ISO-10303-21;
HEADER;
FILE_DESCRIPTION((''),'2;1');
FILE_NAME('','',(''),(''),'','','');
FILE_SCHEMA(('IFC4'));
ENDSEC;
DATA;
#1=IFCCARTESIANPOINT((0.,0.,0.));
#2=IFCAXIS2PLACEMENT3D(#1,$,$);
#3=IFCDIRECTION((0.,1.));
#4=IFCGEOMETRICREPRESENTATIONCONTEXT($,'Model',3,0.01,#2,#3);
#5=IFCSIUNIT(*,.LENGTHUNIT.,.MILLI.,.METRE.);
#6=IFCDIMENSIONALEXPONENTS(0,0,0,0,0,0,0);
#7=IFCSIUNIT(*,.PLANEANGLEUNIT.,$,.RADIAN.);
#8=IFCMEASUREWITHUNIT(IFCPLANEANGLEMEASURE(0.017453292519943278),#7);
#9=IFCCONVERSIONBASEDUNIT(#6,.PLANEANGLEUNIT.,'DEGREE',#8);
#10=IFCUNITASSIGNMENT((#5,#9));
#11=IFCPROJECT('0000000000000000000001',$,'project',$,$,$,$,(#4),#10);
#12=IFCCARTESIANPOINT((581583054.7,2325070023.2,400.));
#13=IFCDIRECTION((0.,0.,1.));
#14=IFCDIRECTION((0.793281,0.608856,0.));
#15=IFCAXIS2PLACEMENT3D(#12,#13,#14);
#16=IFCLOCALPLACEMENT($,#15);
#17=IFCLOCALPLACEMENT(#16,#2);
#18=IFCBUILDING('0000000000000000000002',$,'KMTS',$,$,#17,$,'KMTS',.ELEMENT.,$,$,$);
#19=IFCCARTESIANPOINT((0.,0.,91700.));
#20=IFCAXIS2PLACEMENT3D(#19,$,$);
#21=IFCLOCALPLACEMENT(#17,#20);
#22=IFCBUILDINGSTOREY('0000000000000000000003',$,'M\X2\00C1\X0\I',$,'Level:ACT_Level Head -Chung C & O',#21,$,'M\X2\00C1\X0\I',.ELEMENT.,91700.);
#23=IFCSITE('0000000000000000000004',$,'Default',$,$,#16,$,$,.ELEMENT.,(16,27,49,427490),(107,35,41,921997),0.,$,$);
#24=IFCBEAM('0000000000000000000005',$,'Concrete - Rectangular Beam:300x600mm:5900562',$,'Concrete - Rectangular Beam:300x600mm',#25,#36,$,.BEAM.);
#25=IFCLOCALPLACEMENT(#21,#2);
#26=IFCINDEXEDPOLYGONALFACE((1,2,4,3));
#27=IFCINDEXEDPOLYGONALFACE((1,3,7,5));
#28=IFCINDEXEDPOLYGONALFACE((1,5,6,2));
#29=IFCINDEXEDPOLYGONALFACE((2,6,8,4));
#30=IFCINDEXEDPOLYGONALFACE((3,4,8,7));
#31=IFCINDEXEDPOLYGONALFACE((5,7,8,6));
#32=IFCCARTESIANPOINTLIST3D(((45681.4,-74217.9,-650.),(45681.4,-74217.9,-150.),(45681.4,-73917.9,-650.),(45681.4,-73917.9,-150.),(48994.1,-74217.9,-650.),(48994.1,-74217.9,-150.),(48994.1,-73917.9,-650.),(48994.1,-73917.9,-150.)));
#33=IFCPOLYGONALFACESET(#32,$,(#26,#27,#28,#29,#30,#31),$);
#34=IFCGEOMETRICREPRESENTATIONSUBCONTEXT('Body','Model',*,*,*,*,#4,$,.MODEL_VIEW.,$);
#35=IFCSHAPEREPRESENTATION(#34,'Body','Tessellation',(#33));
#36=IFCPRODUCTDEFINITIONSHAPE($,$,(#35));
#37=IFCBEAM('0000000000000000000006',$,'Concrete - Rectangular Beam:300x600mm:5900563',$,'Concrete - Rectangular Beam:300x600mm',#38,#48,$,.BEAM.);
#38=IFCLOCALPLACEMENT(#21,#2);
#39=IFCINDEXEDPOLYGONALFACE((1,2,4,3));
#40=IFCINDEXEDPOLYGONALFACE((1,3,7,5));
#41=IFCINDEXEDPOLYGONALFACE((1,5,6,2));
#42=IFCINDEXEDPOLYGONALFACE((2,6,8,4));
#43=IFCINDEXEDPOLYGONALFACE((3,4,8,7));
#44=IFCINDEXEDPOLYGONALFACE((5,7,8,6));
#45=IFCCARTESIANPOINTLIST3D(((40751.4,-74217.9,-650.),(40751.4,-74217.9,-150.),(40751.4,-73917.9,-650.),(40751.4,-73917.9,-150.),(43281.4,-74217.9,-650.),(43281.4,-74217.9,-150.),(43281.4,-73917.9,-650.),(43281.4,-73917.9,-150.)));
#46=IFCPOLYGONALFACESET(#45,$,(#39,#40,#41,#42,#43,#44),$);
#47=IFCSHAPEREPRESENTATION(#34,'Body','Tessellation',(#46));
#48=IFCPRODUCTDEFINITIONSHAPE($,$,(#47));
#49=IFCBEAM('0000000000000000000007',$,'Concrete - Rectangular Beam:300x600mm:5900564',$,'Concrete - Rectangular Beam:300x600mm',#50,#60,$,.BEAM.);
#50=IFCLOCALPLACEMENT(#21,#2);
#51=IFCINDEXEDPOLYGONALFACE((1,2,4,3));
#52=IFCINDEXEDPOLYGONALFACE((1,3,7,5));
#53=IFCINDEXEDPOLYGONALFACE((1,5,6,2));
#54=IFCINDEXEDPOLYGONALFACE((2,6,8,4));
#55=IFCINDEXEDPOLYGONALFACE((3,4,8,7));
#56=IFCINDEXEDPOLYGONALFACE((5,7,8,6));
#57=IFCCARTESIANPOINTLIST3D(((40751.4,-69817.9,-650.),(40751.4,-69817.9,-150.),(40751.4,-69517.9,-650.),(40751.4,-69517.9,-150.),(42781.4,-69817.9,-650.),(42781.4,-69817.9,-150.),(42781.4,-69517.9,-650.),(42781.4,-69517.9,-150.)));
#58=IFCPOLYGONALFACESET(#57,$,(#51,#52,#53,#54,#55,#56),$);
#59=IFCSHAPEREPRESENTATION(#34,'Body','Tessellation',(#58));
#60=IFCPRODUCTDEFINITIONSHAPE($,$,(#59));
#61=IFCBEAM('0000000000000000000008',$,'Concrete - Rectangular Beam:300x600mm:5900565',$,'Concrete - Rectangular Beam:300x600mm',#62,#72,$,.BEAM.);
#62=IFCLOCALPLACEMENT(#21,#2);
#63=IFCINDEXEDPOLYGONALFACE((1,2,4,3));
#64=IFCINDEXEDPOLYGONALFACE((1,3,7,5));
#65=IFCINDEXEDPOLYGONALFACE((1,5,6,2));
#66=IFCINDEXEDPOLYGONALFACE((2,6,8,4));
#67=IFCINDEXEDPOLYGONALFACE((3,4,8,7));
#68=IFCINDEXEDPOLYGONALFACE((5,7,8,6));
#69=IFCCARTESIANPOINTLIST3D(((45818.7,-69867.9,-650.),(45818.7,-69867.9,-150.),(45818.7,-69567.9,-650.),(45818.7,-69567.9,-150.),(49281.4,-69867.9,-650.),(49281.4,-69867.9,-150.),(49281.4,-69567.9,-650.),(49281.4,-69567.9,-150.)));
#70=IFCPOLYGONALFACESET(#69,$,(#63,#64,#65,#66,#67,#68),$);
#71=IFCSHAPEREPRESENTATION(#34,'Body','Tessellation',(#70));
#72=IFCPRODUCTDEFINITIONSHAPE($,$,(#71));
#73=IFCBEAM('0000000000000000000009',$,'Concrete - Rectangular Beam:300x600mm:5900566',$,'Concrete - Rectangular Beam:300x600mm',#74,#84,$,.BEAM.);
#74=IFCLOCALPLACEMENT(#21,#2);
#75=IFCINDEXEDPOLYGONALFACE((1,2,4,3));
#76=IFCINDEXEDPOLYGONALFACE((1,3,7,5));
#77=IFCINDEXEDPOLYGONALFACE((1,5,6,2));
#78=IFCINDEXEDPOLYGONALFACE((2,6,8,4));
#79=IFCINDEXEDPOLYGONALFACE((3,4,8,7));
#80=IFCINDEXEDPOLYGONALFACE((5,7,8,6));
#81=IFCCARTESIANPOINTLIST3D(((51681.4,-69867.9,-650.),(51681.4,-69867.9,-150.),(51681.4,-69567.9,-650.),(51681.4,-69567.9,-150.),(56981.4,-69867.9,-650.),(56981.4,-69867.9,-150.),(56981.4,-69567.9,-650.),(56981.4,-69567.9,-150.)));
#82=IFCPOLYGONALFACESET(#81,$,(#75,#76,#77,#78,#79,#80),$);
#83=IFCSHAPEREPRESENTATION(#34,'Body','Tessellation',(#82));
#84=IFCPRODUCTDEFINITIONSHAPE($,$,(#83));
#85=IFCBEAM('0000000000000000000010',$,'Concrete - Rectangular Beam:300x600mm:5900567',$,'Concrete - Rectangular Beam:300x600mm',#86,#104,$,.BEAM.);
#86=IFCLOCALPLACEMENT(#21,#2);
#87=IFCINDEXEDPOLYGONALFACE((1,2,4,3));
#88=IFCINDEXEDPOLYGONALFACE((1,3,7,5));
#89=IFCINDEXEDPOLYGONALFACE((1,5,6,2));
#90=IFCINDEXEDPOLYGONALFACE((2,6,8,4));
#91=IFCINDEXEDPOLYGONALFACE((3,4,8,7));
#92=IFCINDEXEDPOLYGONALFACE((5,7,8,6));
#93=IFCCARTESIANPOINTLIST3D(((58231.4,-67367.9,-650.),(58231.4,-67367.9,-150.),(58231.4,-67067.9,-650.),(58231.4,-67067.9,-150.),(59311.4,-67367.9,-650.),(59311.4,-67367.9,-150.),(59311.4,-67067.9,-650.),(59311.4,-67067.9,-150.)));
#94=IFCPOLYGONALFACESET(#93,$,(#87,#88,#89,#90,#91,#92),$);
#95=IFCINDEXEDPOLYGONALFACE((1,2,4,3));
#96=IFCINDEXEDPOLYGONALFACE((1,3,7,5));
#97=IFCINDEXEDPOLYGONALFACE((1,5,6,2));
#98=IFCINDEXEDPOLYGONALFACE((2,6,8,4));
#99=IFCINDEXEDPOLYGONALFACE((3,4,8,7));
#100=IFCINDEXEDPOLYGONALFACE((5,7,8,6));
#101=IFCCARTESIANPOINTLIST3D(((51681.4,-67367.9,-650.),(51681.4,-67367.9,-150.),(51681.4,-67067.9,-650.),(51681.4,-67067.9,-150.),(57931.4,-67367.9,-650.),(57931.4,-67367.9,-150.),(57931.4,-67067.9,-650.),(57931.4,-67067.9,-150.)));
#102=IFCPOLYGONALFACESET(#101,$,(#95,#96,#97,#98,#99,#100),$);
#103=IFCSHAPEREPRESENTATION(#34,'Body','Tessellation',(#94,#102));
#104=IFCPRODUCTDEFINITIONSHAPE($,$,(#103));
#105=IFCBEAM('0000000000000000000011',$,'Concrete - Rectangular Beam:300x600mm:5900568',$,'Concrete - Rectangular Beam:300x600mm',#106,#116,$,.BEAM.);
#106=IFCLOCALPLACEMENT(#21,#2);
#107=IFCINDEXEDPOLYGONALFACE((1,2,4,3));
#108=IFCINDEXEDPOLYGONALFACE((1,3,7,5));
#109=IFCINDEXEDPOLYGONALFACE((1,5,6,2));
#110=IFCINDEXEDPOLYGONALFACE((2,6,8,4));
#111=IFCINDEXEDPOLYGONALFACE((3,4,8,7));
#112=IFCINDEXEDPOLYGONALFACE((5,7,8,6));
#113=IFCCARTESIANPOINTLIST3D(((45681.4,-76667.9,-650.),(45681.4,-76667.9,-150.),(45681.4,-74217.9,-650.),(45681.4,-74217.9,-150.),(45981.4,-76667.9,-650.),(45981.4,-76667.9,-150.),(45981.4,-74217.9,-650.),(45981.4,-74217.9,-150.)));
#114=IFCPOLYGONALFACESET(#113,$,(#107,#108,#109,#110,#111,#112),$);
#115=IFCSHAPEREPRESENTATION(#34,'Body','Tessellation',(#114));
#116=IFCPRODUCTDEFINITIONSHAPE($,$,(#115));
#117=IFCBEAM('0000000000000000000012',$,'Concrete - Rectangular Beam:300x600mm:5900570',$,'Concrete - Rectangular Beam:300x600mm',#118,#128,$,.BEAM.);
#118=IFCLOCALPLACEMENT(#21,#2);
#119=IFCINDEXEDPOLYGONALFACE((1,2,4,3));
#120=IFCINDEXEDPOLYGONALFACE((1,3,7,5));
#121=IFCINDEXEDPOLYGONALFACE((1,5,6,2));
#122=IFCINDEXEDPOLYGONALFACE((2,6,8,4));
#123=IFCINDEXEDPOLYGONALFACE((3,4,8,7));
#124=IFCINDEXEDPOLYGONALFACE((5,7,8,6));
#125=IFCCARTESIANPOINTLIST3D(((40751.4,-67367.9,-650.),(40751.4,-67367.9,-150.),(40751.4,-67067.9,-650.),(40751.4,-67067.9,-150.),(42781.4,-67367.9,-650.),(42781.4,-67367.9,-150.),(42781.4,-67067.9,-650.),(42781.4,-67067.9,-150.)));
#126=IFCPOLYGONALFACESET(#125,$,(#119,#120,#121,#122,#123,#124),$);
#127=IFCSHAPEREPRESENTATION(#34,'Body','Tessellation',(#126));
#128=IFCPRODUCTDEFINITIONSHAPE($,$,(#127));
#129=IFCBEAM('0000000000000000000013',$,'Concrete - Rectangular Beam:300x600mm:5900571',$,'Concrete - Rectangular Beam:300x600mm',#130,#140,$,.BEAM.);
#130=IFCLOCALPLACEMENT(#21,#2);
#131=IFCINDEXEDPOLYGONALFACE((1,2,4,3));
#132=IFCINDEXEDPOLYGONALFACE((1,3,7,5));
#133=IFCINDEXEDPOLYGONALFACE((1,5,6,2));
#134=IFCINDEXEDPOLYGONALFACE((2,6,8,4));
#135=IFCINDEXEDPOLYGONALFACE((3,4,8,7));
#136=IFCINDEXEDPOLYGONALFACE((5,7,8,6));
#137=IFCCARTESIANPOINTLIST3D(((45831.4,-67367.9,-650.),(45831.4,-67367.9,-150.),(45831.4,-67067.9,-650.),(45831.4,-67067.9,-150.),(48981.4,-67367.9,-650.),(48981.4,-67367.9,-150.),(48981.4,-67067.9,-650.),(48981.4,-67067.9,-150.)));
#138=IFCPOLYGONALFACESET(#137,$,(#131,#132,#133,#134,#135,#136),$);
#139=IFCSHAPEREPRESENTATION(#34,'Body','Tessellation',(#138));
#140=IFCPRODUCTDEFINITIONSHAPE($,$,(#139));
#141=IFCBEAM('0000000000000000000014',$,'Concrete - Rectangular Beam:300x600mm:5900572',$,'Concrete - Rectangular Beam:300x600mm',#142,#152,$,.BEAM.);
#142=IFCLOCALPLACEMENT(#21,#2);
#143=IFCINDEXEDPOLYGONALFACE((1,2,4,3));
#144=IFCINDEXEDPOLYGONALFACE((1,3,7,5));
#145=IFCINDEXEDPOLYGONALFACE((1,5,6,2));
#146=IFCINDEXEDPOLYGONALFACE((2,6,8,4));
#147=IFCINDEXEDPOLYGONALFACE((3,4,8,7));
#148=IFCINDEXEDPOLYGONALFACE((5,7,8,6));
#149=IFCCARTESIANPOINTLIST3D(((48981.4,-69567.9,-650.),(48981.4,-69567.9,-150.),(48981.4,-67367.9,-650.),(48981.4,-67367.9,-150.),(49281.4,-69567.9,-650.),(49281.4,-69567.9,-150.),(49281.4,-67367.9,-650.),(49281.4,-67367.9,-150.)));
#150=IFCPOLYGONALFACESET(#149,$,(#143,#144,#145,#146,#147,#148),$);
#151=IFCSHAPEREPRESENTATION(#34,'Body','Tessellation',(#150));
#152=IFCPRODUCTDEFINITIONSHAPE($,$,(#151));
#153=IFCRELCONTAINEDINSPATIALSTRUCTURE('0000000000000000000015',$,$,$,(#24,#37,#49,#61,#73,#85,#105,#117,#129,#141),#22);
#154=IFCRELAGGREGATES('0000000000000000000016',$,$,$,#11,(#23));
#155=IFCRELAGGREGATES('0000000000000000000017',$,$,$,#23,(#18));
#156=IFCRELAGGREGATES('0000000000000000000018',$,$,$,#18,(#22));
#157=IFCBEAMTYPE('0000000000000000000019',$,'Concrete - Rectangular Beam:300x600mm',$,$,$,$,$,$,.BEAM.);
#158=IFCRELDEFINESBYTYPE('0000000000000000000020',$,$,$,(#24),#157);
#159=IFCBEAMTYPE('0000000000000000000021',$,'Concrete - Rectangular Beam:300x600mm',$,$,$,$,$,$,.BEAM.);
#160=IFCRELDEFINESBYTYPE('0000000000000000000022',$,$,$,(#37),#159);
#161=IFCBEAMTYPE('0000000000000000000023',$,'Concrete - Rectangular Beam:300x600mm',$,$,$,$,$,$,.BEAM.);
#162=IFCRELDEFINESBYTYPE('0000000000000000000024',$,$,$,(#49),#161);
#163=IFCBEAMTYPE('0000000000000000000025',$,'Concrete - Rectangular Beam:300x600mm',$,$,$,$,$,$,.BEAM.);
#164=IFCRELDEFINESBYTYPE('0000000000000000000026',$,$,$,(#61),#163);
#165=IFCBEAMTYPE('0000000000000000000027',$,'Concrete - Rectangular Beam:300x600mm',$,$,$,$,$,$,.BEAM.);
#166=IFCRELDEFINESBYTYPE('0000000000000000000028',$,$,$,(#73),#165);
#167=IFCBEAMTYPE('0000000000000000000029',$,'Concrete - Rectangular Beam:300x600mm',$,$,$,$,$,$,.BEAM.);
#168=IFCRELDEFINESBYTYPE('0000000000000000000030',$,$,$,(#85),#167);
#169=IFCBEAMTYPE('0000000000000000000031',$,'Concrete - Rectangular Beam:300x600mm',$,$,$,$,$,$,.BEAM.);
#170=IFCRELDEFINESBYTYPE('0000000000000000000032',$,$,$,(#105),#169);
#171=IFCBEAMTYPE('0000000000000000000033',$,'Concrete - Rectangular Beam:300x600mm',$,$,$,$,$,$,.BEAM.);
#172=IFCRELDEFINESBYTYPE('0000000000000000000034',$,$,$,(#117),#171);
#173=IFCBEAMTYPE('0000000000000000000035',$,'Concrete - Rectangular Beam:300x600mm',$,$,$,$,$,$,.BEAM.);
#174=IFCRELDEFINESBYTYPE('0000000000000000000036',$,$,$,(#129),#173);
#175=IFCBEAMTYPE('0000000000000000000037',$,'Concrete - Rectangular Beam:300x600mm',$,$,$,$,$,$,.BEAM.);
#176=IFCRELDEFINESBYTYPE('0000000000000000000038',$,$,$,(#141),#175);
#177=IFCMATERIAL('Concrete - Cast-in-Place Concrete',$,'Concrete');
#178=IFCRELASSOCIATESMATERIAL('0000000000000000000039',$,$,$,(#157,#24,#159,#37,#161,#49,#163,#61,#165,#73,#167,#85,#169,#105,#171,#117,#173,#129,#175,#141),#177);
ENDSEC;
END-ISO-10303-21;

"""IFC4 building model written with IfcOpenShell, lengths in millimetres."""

from ifc_helpers import new_model, entity, si_unit, converted_unit, direction, frame, origin, place, context, subcontext, project, spatial, indexed_curve, outline, extrude, source, transform, mapped, material, type_object, type_shapes, element, save


model = new_model("IFC4")

# Units and contexts
model_context = context("Model", 3, precision=0.01, world=origin(), true_north=direction((0.0, 1.0)))
body_context = subcontext(model_context, "Body", "Model", "MODEL_VIEW")
ifc_project = project(units=[si_unit("LENGTHUNIT", "METRE", prefix="MILLI"), converted_unit("PLANEANGLEUNIT", "DEGREE", entity("IfcPlaneAngleMeasure", 0.017453292519943278), si_unit("PLANEANGLEUNIT", "RADIAN"), dimensions=[0, 0, 0, 0, 0, 0, 0])], contexts=[model_context])

# Site, building, storey
site_placement = place(None, frame((581583054.7, 2325070023.2, 400.0), z_axis=(0.0, 0.0, 1.0), x_axis=(0.793281, 0.608856, 0.0)))
site = spatial("IfcSite", under=ifc_project, at=site_placement, Name="Default", CompositionType="ELEMENT", RefLatitude=(16, 27, 49, 427490), RefLongitude=(107, 35, 41, 921997), RefElevation=0.0)
building_placement = place(site_placement, origin())
building = spatial("IfcBuilding", under=site, at=building_placement, Name="KMTS", LongName="KMTS", CompositionType="ELEMENT")
storey_placement = place(building_placement, frame((0.0, 0.0, 91700.0)))
storey = spatial("IfcBuildingStorey", under=building, at=storey_placement, Name="MÁI", ObjectType="Level:ACT_Level Head -Chung C & O", LongName="MÁI", CompositionType="ELEMENT", Elevation=91700.0)

# Beams
ifc_material_1 = material(Name="Concrete - Cast-in-Place Concrete", Category="Concrete")
beam_type_1 = type_object("IfcBeamType", Name="Concrete - Rectangular Beam:300x600mm", PredefinedType="BEAM", material=ifc_material_1)
shared_shape_1 = source(origin(), body_context, "Body", "SweptSolid", [
    extrude(outline(indexed_curve([(-250.0, -150.0), (250.0, -150.0), (250.0, 150.0), (-250.0, 150.0), (-250.0, -150.0)], self_intersect=False)), frame((48994.1, -74067.9, 91300.0), z_axis=(-1.0, 0.0, 0.0), x_axis=(0.0, 0.0, -1.0)), (0.0, 0.0, 1.0), 3312.7),
])
type_shapes(beam_type_1, [shared_shape_1])
beam_1_placement = place(storey_placement, frame((0.0, 0.0, -91700.0)))
element("IfcBeam", 1, at=beam_1_placement, inside=storey, type_object=beam_type_1, material=ifc_material_1, Name="Concrete - Rectangular Beam:300x600mm:5900562", ObjectType="Concrete - Rectangular Beam:300x600mm", PredefinedType="BEAM", context=body_context, shape_type="MappedRepresentation", body=[
    mapped(shared_shape_1, transform((0.0, 0.0, 0.0), scale=1.0)),
])
beam_type_2 = type_object("IfcBeamType", Name="Concrete - Rectangular Beam:300x600mm", PredefinedType="BEAM", material=ifc_material_1)
shared_shape_2 = source(origin(), body_context, "Body", "SweptSolid", [
    extrude(outline(indexed_curve([(-250.0, -150.0), (250.0, -150.0), (250.0, 150.0), (-250.0, 150.0), (-250.0, -150.0)], self_intersect=False)), frame((43281.4, -74067.9, 91300.0), z_axis=(-1.0, 0.0, 0.0), x_axis=(0.0, 0.0, -1.0)), (0.0, 0.0, 1.0), 2530.0),
])
type_shapes(beam_type_2, [shared_shape_2])
beam_2_placement = place(storey_placement, frame((0.0, 0.0, -91700.0)))
element("IfcBeam", 2, at=beam_2_placement, inside=storey, type_object=beam_type_2, material=ifc_material_1, Name="Concrete - Rectangular Beam:300x600mm:5900563", ObjectType="Concrete - Rectangular Beam:300x600mm", PredefinedType="BEAM", context=body_context, shape_type="MappedRepresentation", body=[
    mapped(shared_shape_2, transform((0.0, 0.0, 0.0), scale=1.0)),
])
beam_type_3 = type_object("IfcBeamType", Name="Concrete - Rectangular Beam:300x600mm", PredefinedType="BEAM", material=ifc_material_1)
shared_shape_3 = source(origin(), body_context, "Body", "SweptSolid", [
    extrude(outline(indexed_curve([(-250.0, -150.0), (250.0, -150.0), (250.0, 150.0), (-250.0, 150.0), (-250.0, -150.0)], self_intersect=False)), frame((42781.4, -69667.9, 91300.0), z_axis=(-1.0, 0.0, 0.0), x_axis=(0.0, 0.0, -1.0)), (0.0, 0.0, 1.0), 2030.0),
])
type_shapes(beam_type_3, [shared_shape_3])
beam_3_placement = place(storey_placement, frame((0.0, 0.0, -91700.0)))
element("IfcBeam", 3, at=beam_3_placement, inside=storey, type_object=beam_type_3, material=ifc_material_1, Name="Concrete - Rectangular Beam:300x600mm:5900564", ObjectType="Concrete - Rectangular Beam:300x600mm", PredefinedType="BEAM", context=body_context, shape_type="MappedRepresentation", body=[
    mapped(shared_shape_3, transform((0.0, 0.0, 0.0), scale=1.0)),
])
beam_type_4 = type_object("IfcBeamType", Name="Concrete - Rectangular Beam:300x600mm", PredefinedType="BEAM", material=ifc_material_1)
shared_shape_4 = source(origin(), body_context, "Body", "SweptSolid", [
    extrude(outline(indexed_curve([(-250.0, -150.0), (250.0, -150.0), (250.0, 150.0), (-250.0, 150.0), (-250.0, -150.0)], self_intersect=False)), frame((49281.4, -69717.9, 91300.0), z_axis=(-1.0, 0.0, 0.0), x_axis=(0.0, 0.0, -1.0)), (0.0, 0.0, 1.0), 3462.7),
])
type_shapes(beam_type_4, [shared_shape_4])
beam_4_placement = place(storey_placement, frame((0.0, 0.0, -91700.0)))
element("IfcBeam", 4, at=beam_4_placement, inside=storey, type_object=beam_type_4, material=ifc_material_1, Name="Concrete - Rectangular Beam:300x600mm:5900565", ObjectType="Concrete - Rectangular Beam:300x600mm", PredefinedType="BEAM", context=body_context, shape_type="MappedRepresentation", body=[
    mapped(shared_shape_4, transform((0.0, 0.0, 0.0), scale=1.0)),
])
beam_type_5 = type_object("IfcBeamType", Name="Concrete - Rectangular Beam:300x600mm", PredefinedType="BEAM", material=ifc_material_1)
shared_shape_5 = source(origin(), body_context, "Body", "SweptSolid", [
    extrude(outline(indexed_curve([(-250.0, -150.0), (250.0, -150.0), (250.0, 150.0), (-250.0, 150.0), (-250.0, -150.0)], self_intersect=False)), frame((56981.4, -69717.9, 91300.0), z_axis=(-1.0, 0.0, 0.0), x_axis=(0.0, 0.0, -1.0)), (0.0, 0.0, 1.0), 5300.0),
])
type_shapes(beam_type_5, [shared_shape_5])
beam_5_placement = place(storey_placement, frame((0.0, 0.0, -91700.0)))
element("IfcBeam", 5, at=beam_5_placement, inside=storey, type_object=beam_type_5, material=ifc_material_1, Name="Concrete - Rectangular Beam:300x600mm:5900566", ObjectType="Concrete - Rectangular Beam:300x600mm", PredefinedType="BEAM", context=body_context, shape_type="MappedRepresentation", body=[
    mapped(shared_shape_5, transform((0.0, 0.0, 0.0), scale=1.0)),
])
beam_type_6 = type_object("IfcBeamType", Name="Concrete - Rectangular Beam:300x600mm", PredefinedType="BEAM", material=ifc_material_1)
shared_shape_6 = source(origin(), body_context, "Body", "SweptSolid", [
    extrude(outline(indexed_curve([(-250.0, -150.0), (250.0, -150.0), (250.0, 150.0), (-250.0, 150.0), (-250.0, -150.0)], self_intersect=False)), frame((59311.4, -67217.9, 91300.0), z_axis=(-1.0, 0.0, 0.0), x_axis=(0.0, 0.0, -1.0)), (0.0, 0.0, 1.0), 1080.0),
    extrude(outline(indexed_curve([(-250.0, -150.0), (250.0, -150.0), (250.0, 150.0), (-250.0, 150.0), (-250.0, -150.0)], self_intersect=False)), frame((57931.4, -67217.9, 91300.0), z_axis=(-1.0, 0.0, 0.0), x_axis=(0.0, 0.0, -1.0)), (0.0, 0.0, 1.0), 6250.0),
])
type_shapes(beam_type_6, [shared_shape_6])
beam_6_placement = place(storey_placement, frame((0.0, 0.0, -91700.0)))
element("IfcBeam", 6, at=beam_6_placement, inside=storey, type_object=beam_type_6, material=ifc_material_1, Name="Concrete - Rectangular Beam:300x600mm:5900567", ObjectType="Concrete - Rectangular Beam:300x600mm", PredefinedType="BEAM", context=body_context, shape_type="MappedRepresentation", body=[
    mapped(shared_shape_6, transform((0.0, 0.0, 0.0), scale=1.0)),
])
beam_type_7 = type_object("IfcBeamType", Name="Concrete - Rectangular Beam:300x600mm", PredefinedType="BEAM", material=ifc_material_1)
shared_shape_7 = source(origin(), body_context, "Body", "SweptSolid", [
    extrude(outline(indexed_curve([(-150.0, -250.0), (150.0, -250.0), (150.0, 250.0), (-150.0, 250.0), (-150.0, -250.0)], self_intersect=False)), frame((45831.4, -76667.9, 91300.0), z_axis=(0.0, 1.0, 0.0), x_axis=(-1.0, 0.0, 0.0)), (0.0, 0.0, 1.0), 2450.0),
])
type_shapes(beam_type_7, [shared_shape_7])
beam_7_placement = place(storey_placement, frame((0.0, 0.0, -91700.0)))
element("IfcBeam", 7, at=beam_7_placement, inside=storey, type_object=beam_type_7, material=ifc_material_1, Name="Concrete - Rectangular Beam:300x600mm:5900568", ObjectType="Concrete - Rectangular Beam:300x600mm", PredefinedType="BEAM", context=body_context, shape_type="MappedRepresentation", body=[
    mapped(shared_shape_7, transform((0.0, 0.0, 0.0), scale=1.0)),
])
beam_type_8 = type_object("IfcBeamType", Name="Concrete - Rectangular Beam:300x600mm", PredefinedType="BEAM", material=ifc_material_1)
shared_shape_8 = source(origin(), body_context, "Body", "SweptSolid", [
    extrude(outline(indexed_curve([(-250.0, -150.0), (250.0, -150.0), (250.0, 150.0), (-250.0, 150.0), (-250.0, -150.0)], self_intersect=False)), frame((42781.4, -67217.9, 91300.0), z_axis=(-1.0, 0.0, 0.0), x_axis=(0.0, 0.0, -1.0)), (0.0, 0.0, 1.0), 2030.0),
])
type_shapes(beam_type_8, [shared_shape_8])
beam_8_placement = place(storey_placement, frame((0.0, 0.0, -91700.0)))
element("IfcBeam", 8, at=beam_8_placement, inside=storey, type_object=beam_type_8, material=ifc_material_1, Name="Concrete - Rectangular Beam:300x600mm:5900570", ObjectType="Concrete - Rectangular Beam:300x600mm", PredefinedType="BEAM", context=body_context, shape_type="MappedRepresentation", body=[
    mapped(shared_shape_8, transform((0.0, 0.0, 0.0), scale=1.0)),
])
beam_type_9 = type_object("IfcBeamType", Name="Concrete - Rectangular Beam:300x600mm", PredefinedType="BEAM", material=ifc_material_1)
shared_shape_9 = source(origin(), body_context, "Body", "SweptSolid", [
    extrude(outline(indexed_curve([(-250.0, -150.0), (250.0, -150.0), (250.0, 150.0), (-250.0, 150.0), (-250.0, -150.0)], self_intersect=False)), frame((48981.4, -67217.9, 91300.0), z_axis=(-1.0, 0.0, 0.0), x_axis=(0.0, 0.0, -1.0)), (0.0, 0.0, 1.0), 3150.0),
])
type_shapes(beam_type_9, [shared_shape_9])
beam_9_placement = place(storey_placement, frame((0.0, 0.0, -91700.0)))
element("IfcBeam", 9, at=beam_9_placement, inside=storey, type_object=beam_type_9, material=ifc_material_1, Name="Concrete - Rectangular Beam:300x600mm:5900571", ObjectType="Concrete - Rectangular Beam:300x600mm", PredefinedType="BEAM", context=body_context, shape_type="MappedRepresentation", body=[
    mapped(shared_shape_9, transform((0.0, 0.0, 0.0), scale=1.0)),
])
beam_type_10 = type_object("IfcBeamType", Name="Concrete - Rectangular Beam:300x600mm", PredefinedType="BEAM", material=ifc_material_1)
shared_shape_10 = source(origin(), body_context, "Body", "SweptSolid", [
    extrude(outline(indexed_curve([(-150.0, -250.0), (150.0, -250.0), (150.0, 250.0), (-150.0, 250.0), (-150.0, -250.0)], self_intersect=False)), frame((49131.4, -69567.9, 91300.0), z_axis=(0.0, 1.0, 0.0), x_axis=(-1.0, 0.0, 0.0)), (0.0, 0.0, 1.0), 2200.0),
])
type_shapes(beam_type_10, [shared_shape_10])
beam_10_placement = place(storey_placement, frame((0.0, 0.0, -91700.0)))
element("IfcBeam", 10, at=beam_10_placement, inside=storey, type_object=beam_type_10, material=ifc_material_1, Name="Concrete - Rectangular Beam:300x600mm:5900572", ObjectType="Concrete - Rectangular Beam:300x600mm", PredefinedType="BEAM", context=body_context, shape_type="MappedRepresentation", body=[
    mapped(shared_shape_10, transform((0.0, 0.0, 0.0), scale=1.0)),
])

save(model, "model.ifc")
